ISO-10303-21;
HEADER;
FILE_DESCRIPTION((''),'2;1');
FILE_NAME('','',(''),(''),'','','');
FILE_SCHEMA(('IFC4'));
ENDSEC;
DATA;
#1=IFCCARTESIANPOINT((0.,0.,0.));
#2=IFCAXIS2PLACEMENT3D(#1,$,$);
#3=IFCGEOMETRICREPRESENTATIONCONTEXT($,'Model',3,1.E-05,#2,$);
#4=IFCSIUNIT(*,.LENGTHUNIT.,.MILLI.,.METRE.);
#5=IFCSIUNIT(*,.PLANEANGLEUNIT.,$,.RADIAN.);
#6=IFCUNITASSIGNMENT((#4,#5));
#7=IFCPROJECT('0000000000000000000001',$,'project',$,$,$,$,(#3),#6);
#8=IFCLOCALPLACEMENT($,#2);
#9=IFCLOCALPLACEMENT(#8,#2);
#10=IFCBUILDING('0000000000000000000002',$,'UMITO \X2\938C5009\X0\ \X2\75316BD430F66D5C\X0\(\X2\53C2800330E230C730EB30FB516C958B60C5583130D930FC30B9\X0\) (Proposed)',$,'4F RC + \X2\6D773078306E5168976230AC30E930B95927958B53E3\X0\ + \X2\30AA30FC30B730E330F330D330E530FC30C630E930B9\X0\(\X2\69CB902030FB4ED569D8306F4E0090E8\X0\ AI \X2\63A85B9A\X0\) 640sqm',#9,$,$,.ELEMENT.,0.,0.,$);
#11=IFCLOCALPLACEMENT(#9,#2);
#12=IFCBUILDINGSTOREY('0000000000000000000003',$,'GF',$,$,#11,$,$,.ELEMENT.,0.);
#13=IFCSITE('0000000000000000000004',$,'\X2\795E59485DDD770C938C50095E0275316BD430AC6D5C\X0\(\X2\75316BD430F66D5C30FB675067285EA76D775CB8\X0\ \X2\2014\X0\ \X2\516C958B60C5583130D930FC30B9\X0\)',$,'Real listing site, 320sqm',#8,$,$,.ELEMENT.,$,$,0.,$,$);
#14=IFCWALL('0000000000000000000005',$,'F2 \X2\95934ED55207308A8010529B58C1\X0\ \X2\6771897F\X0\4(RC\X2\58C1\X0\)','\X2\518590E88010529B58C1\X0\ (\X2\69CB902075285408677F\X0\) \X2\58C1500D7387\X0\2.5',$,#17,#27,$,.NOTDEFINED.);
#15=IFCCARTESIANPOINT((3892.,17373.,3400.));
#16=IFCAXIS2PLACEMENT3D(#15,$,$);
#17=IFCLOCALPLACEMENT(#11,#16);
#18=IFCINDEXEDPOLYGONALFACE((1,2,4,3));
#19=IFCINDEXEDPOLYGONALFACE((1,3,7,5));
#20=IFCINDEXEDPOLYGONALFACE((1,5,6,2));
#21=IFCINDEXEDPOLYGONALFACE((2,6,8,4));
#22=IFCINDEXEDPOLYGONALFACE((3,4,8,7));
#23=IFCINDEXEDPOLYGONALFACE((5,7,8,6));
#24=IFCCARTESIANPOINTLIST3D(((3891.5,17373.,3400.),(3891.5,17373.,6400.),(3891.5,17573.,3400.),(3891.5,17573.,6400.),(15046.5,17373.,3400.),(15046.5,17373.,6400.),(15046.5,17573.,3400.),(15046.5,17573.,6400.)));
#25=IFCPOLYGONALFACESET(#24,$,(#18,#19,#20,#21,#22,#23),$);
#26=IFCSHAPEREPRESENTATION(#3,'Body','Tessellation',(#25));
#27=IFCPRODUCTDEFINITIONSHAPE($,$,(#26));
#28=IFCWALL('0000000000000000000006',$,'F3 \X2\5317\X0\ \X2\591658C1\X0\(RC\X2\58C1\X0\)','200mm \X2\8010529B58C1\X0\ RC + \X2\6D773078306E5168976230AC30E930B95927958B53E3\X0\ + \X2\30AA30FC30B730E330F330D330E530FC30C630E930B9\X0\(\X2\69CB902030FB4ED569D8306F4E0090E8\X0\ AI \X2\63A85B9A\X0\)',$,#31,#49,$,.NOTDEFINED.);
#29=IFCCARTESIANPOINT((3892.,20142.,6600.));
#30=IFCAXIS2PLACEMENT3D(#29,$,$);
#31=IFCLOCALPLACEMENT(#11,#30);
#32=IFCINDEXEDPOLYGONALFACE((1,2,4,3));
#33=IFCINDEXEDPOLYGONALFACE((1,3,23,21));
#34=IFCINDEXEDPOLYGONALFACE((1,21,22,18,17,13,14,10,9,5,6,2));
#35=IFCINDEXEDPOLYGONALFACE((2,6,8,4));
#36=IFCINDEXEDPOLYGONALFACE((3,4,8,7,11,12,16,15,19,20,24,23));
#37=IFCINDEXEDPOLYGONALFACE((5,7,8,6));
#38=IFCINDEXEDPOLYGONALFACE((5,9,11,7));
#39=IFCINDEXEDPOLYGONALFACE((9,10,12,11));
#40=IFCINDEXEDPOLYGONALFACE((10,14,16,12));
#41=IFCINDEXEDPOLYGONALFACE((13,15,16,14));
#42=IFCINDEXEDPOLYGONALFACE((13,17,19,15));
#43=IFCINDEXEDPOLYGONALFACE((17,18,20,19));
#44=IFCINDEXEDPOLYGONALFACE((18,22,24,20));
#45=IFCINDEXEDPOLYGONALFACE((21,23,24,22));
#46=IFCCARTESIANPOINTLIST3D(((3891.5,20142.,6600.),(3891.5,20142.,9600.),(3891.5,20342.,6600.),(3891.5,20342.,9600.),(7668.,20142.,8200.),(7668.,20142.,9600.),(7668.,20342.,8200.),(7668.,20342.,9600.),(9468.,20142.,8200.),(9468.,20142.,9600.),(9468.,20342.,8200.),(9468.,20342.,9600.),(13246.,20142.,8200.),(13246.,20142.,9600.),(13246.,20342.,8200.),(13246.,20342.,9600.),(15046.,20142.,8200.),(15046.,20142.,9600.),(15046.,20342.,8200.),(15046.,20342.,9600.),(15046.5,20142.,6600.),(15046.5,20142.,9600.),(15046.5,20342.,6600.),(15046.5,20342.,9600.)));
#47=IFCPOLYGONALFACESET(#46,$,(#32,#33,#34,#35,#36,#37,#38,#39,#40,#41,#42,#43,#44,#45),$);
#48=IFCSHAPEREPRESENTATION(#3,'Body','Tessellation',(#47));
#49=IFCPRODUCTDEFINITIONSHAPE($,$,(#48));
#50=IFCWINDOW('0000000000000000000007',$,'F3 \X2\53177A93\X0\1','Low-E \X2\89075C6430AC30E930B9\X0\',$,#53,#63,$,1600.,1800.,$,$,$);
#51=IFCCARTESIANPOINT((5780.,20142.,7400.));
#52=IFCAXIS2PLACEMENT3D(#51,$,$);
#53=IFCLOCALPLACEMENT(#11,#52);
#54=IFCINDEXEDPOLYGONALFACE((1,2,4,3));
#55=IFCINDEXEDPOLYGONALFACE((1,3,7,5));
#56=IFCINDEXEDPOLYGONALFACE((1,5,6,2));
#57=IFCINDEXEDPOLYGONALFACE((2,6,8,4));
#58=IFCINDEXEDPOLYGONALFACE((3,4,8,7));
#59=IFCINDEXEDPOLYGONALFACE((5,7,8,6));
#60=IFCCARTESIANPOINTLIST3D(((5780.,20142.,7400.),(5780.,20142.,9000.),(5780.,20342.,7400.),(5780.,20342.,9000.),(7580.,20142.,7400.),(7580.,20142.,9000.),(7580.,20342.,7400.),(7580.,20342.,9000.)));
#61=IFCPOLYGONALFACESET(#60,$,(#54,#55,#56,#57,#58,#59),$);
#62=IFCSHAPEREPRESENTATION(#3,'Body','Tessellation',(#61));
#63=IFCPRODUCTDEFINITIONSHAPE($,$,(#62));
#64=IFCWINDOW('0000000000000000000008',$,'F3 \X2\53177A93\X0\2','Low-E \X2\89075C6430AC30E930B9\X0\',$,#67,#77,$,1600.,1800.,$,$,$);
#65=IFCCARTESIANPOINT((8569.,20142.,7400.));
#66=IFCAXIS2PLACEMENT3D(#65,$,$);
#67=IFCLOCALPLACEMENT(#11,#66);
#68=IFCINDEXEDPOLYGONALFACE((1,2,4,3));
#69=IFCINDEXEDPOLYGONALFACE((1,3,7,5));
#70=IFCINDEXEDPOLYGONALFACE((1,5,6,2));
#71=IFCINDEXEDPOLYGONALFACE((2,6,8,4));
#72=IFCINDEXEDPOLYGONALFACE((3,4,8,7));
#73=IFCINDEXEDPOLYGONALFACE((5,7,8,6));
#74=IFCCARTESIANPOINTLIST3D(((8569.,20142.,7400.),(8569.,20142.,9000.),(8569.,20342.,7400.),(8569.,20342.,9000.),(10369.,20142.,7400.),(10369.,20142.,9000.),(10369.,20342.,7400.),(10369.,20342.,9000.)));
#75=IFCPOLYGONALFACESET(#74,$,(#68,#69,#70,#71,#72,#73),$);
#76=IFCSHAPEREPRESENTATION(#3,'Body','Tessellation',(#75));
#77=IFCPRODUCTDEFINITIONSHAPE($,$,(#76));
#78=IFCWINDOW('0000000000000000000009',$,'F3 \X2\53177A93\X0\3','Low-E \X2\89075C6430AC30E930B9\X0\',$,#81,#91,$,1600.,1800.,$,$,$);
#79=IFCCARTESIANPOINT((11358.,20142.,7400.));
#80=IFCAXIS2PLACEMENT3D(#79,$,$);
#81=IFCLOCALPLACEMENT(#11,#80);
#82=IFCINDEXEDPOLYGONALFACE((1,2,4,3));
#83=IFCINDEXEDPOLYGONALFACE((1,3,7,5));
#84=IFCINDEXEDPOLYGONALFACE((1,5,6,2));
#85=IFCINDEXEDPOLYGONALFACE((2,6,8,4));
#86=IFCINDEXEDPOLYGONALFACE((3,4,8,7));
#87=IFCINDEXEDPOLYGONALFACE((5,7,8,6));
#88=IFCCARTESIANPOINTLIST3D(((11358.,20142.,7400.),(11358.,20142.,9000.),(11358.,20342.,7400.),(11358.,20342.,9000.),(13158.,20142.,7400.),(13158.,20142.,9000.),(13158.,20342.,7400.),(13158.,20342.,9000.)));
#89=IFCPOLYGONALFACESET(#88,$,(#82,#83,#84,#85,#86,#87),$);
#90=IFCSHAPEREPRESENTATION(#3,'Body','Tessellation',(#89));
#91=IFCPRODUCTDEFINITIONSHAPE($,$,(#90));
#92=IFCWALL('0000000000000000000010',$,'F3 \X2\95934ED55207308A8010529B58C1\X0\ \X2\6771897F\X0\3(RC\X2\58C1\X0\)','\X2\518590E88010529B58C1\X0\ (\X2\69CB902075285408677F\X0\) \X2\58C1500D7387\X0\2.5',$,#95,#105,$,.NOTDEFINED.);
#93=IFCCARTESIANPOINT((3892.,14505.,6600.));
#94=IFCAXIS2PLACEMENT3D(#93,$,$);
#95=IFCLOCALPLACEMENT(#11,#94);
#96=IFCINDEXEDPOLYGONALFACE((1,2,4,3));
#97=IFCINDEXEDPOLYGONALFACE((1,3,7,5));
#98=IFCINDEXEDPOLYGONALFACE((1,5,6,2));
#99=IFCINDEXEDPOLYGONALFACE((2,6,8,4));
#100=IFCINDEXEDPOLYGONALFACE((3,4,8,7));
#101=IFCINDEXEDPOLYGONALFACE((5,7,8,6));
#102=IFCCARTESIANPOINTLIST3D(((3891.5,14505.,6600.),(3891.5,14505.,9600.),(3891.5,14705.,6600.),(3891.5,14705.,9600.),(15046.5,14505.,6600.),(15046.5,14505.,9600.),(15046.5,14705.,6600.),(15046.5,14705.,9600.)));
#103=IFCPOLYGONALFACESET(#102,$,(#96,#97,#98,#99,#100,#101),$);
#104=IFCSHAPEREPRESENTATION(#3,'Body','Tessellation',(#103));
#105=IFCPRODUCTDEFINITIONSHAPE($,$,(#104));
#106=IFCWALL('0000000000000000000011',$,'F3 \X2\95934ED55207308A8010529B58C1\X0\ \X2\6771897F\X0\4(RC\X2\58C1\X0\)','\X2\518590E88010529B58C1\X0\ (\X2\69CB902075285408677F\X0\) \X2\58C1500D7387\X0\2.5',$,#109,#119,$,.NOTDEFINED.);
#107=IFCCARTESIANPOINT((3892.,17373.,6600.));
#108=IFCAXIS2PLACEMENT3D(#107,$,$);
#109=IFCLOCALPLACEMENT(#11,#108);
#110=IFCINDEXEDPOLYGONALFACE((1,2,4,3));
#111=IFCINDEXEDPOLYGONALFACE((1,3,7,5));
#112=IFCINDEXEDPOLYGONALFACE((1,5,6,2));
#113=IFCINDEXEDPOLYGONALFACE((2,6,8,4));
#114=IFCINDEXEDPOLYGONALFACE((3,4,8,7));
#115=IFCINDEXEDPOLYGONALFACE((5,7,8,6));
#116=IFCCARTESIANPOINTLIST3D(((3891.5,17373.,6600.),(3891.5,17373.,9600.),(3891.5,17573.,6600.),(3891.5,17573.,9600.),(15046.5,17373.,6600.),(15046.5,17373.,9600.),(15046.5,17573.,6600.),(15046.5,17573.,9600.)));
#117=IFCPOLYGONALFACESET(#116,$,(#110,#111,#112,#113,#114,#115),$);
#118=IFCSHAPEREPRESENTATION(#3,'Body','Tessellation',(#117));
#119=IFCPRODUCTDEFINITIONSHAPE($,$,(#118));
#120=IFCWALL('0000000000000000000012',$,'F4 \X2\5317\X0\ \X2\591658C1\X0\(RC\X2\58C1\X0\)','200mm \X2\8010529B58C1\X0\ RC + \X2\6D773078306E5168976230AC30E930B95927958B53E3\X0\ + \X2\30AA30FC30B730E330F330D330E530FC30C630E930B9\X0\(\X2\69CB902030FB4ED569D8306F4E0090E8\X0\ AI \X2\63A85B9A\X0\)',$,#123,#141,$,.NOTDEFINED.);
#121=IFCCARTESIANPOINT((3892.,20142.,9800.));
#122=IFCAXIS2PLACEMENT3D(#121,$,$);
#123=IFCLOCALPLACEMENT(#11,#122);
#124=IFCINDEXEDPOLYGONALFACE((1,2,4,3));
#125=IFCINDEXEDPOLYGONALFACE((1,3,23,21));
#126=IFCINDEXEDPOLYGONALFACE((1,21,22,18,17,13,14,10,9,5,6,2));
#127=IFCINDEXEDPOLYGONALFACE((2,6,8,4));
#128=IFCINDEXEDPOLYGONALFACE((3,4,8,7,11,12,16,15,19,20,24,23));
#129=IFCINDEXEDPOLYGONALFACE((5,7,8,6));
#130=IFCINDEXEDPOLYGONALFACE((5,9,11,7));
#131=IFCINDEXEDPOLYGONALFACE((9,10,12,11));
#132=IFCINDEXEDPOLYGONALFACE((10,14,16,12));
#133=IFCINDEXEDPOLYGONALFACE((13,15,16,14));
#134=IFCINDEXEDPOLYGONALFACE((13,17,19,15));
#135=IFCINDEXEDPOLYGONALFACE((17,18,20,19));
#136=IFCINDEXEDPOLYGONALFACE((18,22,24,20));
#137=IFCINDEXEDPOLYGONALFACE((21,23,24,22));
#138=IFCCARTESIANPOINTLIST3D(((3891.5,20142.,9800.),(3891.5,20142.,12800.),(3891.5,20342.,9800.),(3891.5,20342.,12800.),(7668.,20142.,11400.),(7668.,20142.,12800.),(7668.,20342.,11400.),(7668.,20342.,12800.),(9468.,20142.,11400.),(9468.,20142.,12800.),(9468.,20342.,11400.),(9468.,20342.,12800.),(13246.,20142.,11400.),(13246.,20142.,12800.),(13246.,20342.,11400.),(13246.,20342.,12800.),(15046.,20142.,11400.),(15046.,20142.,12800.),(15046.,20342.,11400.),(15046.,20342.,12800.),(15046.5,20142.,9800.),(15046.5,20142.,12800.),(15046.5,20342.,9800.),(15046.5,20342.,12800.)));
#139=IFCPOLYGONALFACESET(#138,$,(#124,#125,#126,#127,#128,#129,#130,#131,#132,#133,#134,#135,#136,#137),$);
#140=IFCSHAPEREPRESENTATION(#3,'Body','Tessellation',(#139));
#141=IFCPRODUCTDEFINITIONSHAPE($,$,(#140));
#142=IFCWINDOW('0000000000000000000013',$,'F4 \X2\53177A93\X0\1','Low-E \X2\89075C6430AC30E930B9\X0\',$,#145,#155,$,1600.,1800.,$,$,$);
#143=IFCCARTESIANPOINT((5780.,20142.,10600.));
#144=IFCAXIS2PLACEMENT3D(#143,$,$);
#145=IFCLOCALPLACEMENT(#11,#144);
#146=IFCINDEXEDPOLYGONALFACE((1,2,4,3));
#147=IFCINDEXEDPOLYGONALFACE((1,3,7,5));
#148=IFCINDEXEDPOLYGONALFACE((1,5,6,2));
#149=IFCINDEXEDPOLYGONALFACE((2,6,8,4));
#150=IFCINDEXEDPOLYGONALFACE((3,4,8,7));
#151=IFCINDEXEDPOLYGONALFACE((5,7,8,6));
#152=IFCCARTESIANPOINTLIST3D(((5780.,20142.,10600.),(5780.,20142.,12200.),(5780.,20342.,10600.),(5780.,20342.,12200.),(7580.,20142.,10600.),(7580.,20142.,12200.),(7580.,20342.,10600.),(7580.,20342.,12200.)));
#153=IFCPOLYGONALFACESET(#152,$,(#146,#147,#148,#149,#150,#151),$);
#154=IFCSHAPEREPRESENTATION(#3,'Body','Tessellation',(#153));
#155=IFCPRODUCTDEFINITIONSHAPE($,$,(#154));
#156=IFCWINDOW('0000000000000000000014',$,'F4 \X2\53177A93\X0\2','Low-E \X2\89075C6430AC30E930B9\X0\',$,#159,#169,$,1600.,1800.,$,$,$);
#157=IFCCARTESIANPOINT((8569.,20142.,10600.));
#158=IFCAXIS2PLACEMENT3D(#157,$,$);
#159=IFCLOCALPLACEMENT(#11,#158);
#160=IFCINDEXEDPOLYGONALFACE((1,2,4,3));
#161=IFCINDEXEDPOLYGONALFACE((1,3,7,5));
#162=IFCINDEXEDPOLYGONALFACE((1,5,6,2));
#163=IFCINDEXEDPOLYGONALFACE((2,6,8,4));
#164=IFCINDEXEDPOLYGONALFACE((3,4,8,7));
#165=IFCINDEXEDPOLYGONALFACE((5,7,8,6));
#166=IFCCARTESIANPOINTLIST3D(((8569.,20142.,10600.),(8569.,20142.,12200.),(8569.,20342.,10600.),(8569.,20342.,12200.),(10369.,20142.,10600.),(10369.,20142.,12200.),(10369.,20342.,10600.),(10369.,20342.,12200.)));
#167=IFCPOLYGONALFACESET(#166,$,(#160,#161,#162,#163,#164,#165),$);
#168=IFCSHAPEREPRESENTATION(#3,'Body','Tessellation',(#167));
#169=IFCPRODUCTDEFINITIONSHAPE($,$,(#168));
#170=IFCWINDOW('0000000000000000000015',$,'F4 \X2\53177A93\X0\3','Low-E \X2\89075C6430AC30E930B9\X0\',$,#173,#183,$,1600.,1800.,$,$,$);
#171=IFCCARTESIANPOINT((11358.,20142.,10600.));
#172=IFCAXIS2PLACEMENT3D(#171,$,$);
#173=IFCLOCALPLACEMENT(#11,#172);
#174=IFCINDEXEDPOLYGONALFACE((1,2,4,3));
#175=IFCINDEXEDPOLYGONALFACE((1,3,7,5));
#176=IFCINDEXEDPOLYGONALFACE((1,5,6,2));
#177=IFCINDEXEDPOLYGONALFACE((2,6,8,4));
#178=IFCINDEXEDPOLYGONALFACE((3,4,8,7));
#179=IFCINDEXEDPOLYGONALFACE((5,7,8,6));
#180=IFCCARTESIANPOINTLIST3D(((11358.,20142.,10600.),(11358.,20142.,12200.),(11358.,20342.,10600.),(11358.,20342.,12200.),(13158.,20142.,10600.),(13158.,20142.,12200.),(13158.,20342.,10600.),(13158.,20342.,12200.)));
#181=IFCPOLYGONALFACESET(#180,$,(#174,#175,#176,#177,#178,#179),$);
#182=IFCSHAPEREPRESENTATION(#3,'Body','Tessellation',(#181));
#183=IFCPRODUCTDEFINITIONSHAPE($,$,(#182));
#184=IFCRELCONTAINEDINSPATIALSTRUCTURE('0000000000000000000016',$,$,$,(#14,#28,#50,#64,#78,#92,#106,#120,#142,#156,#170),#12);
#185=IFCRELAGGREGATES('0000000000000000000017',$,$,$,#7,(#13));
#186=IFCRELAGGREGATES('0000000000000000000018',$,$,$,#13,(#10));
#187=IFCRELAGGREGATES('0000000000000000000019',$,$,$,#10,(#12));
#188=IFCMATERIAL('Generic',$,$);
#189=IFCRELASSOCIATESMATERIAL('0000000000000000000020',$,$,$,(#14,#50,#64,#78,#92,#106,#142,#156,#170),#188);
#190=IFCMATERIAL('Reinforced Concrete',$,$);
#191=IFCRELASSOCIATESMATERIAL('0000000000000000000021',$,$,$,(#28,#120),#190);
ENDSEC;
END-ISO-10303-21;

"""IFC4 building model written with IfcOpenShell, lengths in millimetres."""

from ifc_helpers import new_model, si_unit, frame, frame_2d, origin, place, context, project, spatial, rectangle, extrude, material, element, fill, save


model = new_model("IFC4")

# Units and contexts
model_context = context("Model", 3, precision=1e-05, world=origin())
ifc_project = project(units=[si_unit("LENGTHUNIT", "METRE", prefix="MILLI"), si_unit("PLANEANGLEUNIT", "RADIAN")], contexts=[model_context])

# Site, building, storey
site_placement = place(None, origin())
site = spatial("IfcSite", under=ifc_project, at=site_placement, Name="神奈川県鎌倉市由比ガ浜(由比ヶ浜・材木座海岸 — 公開情報ベース)", ObjectType="Real listing site, 320sqm", CompositionType="ELEMENT", RefElevation=0.0)
building_placement = place(site_placement, origin())
building = spatial("IfcBuilding", under=site, at=building_placement, Name="UMITO 鎌倉 由比ヶ浜(参考モデル・公開情報ベース) (Proposed)", ObjectType="4F RC + 海への全面ガラス大開口 + オーシャンビューテラス(構造・仕様は一部 AI 推定) 640sqm", CompositionType="ELEMENT", ElevationOfRefHeight=0.0, ElevationOfTerrain=0.0)
storey_placement = place(building_placement, origin())
storey = spatial("IfcBuildingStorey", under=building, at=storey_placement, Name="GF", CompositionType="ELEMENT", Elevation=0.0)

# Shared definitions
ifc_material_1 = material(Name="Reinforced Concrete")
ifc_material_2 = material(Name="Generic")

# Wall
wall_1_placement = place(storey_placement, frame((3892.0, 17373.0, 3400.0)))
element("IfcWall", 1, at=wall_1_placement, inside=storey, material=ifc_material_2, Name="F2 間仕切り耐力壁 東西4(RC壁)", Description="内部耐力壁 (構造用合板) 壁倍率2.5", PredefinedType="NOTDEFINED", context=model_context, shape_type="SweptSolid", body=[
    extrude(rectangle(XDim=11155.0, YDim=200.0, at=frame_2d((5577.0, 100.0))), frame((3892.0, 17373.0, 3400.0)), (0.0, 0.0, 1.0), 3000.0),
])

# Wall, openings, windows
wall_2_placement = place(storey_placement, frame((3892.0, 20142.0, 6600.0)))
wall_2 = element("IfcWall", 2, at=wall_2_placement, inside=storey, material=ifc_material_1, Name="F3 北 外壁(RC壁)", Description="200mm 耐力壁 RC + 海への全面ガラス大開口 + オーシャンビューテラス(構造・仕様は一部 AI 推定)", PredefinedType="NOTDEFINED", context=model_context, shape_type="SweptSolid", body=[
    extrude(rectangle(XDim=11155.0, YDim=200.0, at=frame_2d((5577.0, 100.0))), frame((3892.0, 20142.0, 6600.0)), (0.0, 0.0, 1.0), 3000.0),
])
opening_1_placement = place(storey_placement, frame((5780.0, 20142.0, 7400.0)))
opening_1 = element("IfcOpeningElement", 3, at=opening_1_placement, cuts=wall_2, PredefinedType="NOTDEFINED", context=model_context, shape_type="SweptSolid", body=[
    extrude(rectangle(XDim=1800.0, YDim=200.0, at=frame_2d((900.0, 100.0))), frame((5780.0, 20142.0, 7400.0)), (0.0, 0.0, 1.0), 1600.0),
])
opening_2_placement = place(storey_placement, frame((8569.0, 20142.0, 7400.0)))
opening_2 = element("IfcOpeningElement", 4, at=opening_2_placement, cuts=wall_2, PredefinedType="NOTDEFINED", context=model_context, shape_type="SweptSolid", body=[
    extrude(rectangle(XDim=1800.0, YDim=200.0, at=frame_2d((900.0, 100.0))), frame((8569.0, 20142.0, 7400.0)), (0.0, 0.0, 1.0), 1600.0),
])
opening_3_placement = place(storey_placement, frame((11358.0, 20142.0, 7400.0)))
opening_3 = element("IfcOpeningElement", 5, at=opening_3_placement, cuts=wall_2, PredefinedType="NOTDEFINED", context=model_context, shape_type="SweptSolid", body=[
    extrude(rectangle(XDim=1800.0, YDim=200.0, at=frame_2d((900.0, 100.0))), frame((11358.0, 20142.0, 7400.0)), (0.0, 0.0, 1.0), 1600.0),
])
window_1_placement = place(storey_placement, frame((5780.0, 20142.0, 7400.0)))
window_1 = element("IfcWindow", 6, at=window_1_placement, inside=storey, material=ifc_material_2, Name="F3 北窓1", Description="Low-E 複層ガラス", OverallHeight=1600.0, OverallWidth=1800.0, context=model_context, shape_type="SweptSolid", body=[
    extrude(rectangle(XDim=1800.0, YDim=200.0, at=frame_2d((900.0, 100.0))), frame((5780.0, 20142.0, 7400.0)), (0.0, 0.0, 1.0), 1600.0),
])
fill(opening_1, window_1)
window_2_placement = place(storey_placement, frame((8569.0, 20142.0, 7400.0)))
window_2 = element("IfcWindow", 7, at=window_2_placement, inside=storey, material=ifc_material_2, Name="F3 北窓2", Description="Low-E 複層ガラス", OverallHeight=1600.0, OverallWidth=1800.0, context=model_context, shape_type="SweptSolid", body=[
    extrude(rectangle(XDim=1800.0, YDim=200.0, at=frame_2d((900.0, 100.0))), frame((8569.0, 20142.0, 7400.0)), (0.0, 0.0, 1.0), 1600.0),
])
fill(opening_2, window_2)
window_3_placement = place(storey_placement, frame((11358.0, 20142.0, 7400.0)))
window_3 = element("IfcWindow", 8, at=window_3_placement, inside=storey, material=ifc_material_2, Name="F3 北窓3", Description="Low-E 複層ガラス", OverallHeight=1600.0, OverallWidth=1800.0, context=model_context, shape_type="SweptSolid", body=[
    extrude(rectangle(XDim=1800.0, YDim=200.0, at=frame_2d((900.0, 100.0))), frame((11358.0, 20142.0, 7400.0)), (0.0, 0.0, 1.0), 1600.0),
])
fill(opening_3, window_3)

# Walls
wall_3_placement = place(storey_placement, frame((3892.0, 14505.0, 6600.0)))
element("IfcWall", 9, at=wall_3_placement, inside=storey, material=ifc_material_2, Name="F3 間仕切り耐力壁 東西3(RC壁)", Description="内部耐力壁 (構造用合板) 壁倍率2.5", PredefinedType="NOTDEFINED", context=model_context, shape_type="SweptSolid", body=[
    extrude(rectangle(XDim=11155.0, YDim=200.0, at=frame_2d((5577.0, 100.0))), frame((3892.0, 14505.0, 6600.0)), (0.0, 0.0, 1.0), 3000.0),
])
wall_4_placement = place(storey_placement, frame((3892.0, 17373.0, 6600.0)))
element("IfcWall", 10, at=wall_4_placement, inside=storey, material=ifc_material_2, Name="F3 間仕切り耐力壁 東西4(RC壁)", Description="内部耐力壁 (構造用合板) 壁倍率2.5", PredefinedType="NOTDEFINED", context=model_context, shape_type="SweptSolid", body=[
    extrude(rectangle(XDim=11155.0, YDim=200.0, at=frame_2d((5577.0, 100.0))), frame((3892.0, 17373.0, 6600.0)), (0.0, 0.0, 1.0), 3000.0),
])

# Wall, openings, windows
wall_5_placement = place(storey_placement, frame((3892.0, 20142.0, 9800.0)))
wall_5 = element("IfcWall", 11, at=wall_5_placement, inside=storey, material=ifc_material_1, Name="F4 北 外壁(RC壁)", Description="200mm 耐力壁 RC + 海への全面ガラス大開口 + オーシャンビューテラス(構造・仕様は一部 AI 推定)", PredefinedType="NOTDEFINED", context=model_context, shape_type="SweptSolid", body=[
    extrude(rectangle(XDim=11155.0, YDim=200.0, at=frame_2d((5577.0, 100.0))), frame((3892.0, 20142.0, 9800.0)), (0.0, 0.0, 1.0), 3000.0),
])
opening_4_placement = place(storey_placement, frame((5780.0, 20142.0, 10600.0)))
opening_4 = element("IfcOpeningElement", 12, at=opening_4_placement, cuts=wall_5, PredefinedType="NOTDEFINED", context=model_context, shape_type="SweptSolid", body=[
    extrude(rectangle(XDim=1800.0, YDim=200.0, at=frame_2d((900.0, 100.0))), frame((5780.0, 20142.0, 10600.0)), (0.0, 0.0, 1.0), 1600.0),
])
opening_5_placement = place(storey_placement, frame((8569.0, 20142.0, 10600.0)))
opening_5 = element("IfcOpeningElement", 13, at=opening_5_placement, cuts=wall_5, PredefinedType="NOTDEFINED", context=model_context, shape_type="SweptSolid", body=[
    extrude(rectangle(XDim=1800.0, YDim=200.0, at=frame_2d((900.0, 100.0))), frame((8569.0, 20142.0, 10600.0)), (0.0, 0.0, 1.0), 1600.0),
])
opening_6_placement = place(storey_placement, frame((11358.0, 20142.0, 10600.0)))
opening_6 = element("IfcOpeningElement", 14, at=opening_6_placement, cuts=wall_5, PredefinedType="NOTDEFINED", context=model_context, shape_type="SweptSolid", body=[
    extrude(rectangle(XDim=1800.0, YDim=200.0, at=frame_2d((900.0, 100.0))), frame((11358.0, 20142.0, 10600.0)), (0.0, 0.0, 1.0), 1600.0),
])
window_4_placement = place(storey_placement, frame((5780.0, 20142.0, 10600.0)))
window_4 = element("IfcWindow", 15, at=window_4_placement, inside=storey, material=ifc_material_2, Name="F4 北窓1", Description="Low-E 複層ガラス", OverallHeight=1600.0, OverallWidth=1800.0, context=model_context, shape_type="SweptSolid", body=[
    extrude(rectangle(XDim=1800.0, YDim=200.0, at=frame_2d((900.0, 100.0))), frame((5780.0, 20142.0, 10600.0)), (0.0, 0.0, 1.0), 1600.0),
])
fill(opening_4, window_4)
window_5_placement = place(storey_placement, frame((8569.0, 20142.0, 10600.0)))
window_5 = element("IfcWindow", 16, at=window_5_placement, inside=storey, material=ifc_material_2, Name="F4 北窓2", Description="Low-E 複層ガラス", OverallHeight=1600.0, OverallWidth=1800.0, context=model_context, shape_type="SweptSolid", body=[
    extrude(rectangle(XDim=1800.0, YDim=200.0, at=frame_2d((900.0, 100.0))), frame((8569.0, 20142.0, 10600.0)), (0.0, 0.0, 1.0), 1600.0),
])
fill(opening_5, window_5)
window_6_placement = place(storey_placement, frame((11358.0, 20142.0, 10600.0)))
window_6 = element("IfcWindow", 17, at=window_6_placement, inside=storey, material=ifc_material_2, Name="F4 北窓3", Description="Low-E 複層ガラス", OverallHeight=1600.0, OverallWidth=1800.0, context=model_context, shape_type="SweptSolid", body=[
    extrude(rectangle(XDim=1800.0, YDim=200.0, at=frame_2d((900.0, 100.0))), frame((11358.0, 20142.0, 10600.0)), (0.0, 0.0, 1.0), 1600.0),
])
fill(opening_6, window_6)

save(model, "model.ifc")
